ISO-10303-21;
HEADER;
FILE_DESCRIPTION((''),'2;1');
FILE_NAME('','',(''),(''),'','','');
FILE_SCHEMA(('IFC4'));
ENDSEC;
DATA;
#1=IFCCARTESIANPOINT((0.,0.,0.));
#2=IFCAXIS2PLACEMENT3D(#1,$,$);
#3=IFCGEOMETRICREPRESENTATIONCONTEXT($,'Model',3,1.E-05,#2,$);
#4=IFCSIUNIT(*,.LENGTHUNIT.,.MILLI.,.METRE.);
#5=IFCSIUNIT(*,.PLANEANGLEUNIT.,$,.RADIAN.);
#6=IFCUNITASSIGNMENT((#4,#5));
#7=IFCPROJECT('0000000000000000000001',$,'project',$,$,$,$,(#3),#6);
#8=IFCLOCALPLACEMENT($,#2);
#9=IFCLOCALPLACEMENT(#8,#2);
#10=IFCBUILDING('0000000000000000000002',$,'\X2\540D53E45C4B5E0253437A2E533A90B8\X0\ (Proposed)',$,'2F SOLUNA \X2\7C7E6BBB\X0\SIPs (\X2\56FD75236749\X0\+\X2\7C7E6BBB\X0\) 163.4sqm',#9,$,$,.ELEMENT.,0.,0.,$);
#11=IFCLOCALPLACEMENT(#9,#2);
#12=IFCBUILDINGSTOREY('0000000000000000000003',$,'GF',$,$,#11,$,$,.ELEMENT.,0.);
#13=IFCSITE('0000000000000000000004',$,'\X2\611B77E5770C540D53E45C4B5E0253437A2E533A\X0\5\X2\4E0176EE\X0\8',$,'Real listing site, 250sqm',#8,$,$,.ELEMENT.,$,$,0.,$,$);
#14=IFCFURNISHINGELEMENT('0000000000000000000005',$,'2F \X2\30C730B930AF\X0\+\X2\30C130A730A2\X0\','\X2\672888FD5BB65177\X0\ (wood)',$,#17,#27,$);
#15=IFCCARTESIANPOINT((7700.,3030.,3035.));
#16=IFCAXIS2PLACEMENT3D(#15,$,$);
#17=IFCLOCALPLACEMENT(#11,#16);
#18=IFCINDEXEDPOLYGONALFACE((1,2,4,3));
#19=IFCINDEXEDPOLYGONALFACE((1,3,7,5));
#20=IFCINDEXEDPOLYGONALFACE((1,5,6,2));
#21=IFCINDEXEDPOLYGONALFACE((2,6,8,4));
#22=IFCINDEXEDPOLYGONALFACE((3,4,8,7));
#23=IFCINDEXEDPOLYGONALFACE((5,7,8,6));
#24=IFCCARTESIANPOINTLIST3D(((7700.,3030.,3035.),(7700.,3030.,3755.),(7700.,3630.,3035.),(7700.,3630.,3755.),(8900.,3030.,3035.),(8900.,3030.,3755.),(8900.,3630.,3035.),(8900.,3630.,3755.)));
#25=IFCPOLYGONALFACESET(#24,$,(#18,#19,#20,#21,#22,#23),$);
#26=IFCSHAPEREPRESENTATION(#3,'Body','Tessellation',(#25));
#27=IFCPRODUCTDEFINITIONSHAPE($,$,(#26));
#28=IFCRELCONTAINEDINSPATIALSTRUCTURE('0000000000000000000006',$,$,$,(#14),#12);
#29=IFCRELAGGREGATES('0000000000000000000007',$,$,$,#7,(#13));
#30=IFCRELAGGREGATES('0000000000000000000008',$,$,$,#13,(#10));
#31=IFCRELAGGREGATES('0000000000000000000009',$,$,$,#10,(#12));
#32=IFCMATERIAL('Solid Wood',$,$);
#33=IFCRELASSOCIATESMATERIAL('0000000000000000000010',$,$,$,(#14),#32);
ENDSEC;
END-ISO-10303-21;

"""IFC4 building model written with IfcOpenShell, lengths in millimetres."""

from ifc_helpers import new_model, si_unit, frame, frame_2d, origin, place, context, project, spatial, rectangle, extrude, material, element, save


model = new_model("IFC4")

# Units and contexts
model_context = context("Model", 3, precision=1e-05, world=origin())
ifc_project = project(units=[si_unit("LENGTHUNIT", "METRE", prefix="MILLI"), si_unit("PLANEANGLEUNIT", "RADIAN")], contexts=[model_context])

# Site, building, storey
site_placement = place(None, origin())
site = spatial("IfcSite", under=ifc_project, at=site_placement, Name="愛知県名古屋市千種区5丁目8", ObjectType="Real listing site, 250sqm", CompositionType="ELEMENT", RefElevation=0.0)
building_placement = place(site_placement, origin())
building = spatial("IfcBuilding", under=site, at=building_placement, Name="名古屋市千種区邸 (Proposed)", ObjectType="2F SOLUNA 籾殻SIPs (国産杉+籾殻) 163.4sqm", CompositionType="ELEMENT", ElevationOfRefHeight=0.0, ElevationOfTerrain=0.0)
storey_placement = place(building_placement, origin())
storey = spatial("IfcBuildingStorey", under=building, at=storey_placement, Name="GF", CompositionType="ELEMENT", Elevation=0.0)

# Shared definitions
ifc_material_1 = material(Name="Solid Wood")

# Furnishing element
furnishing_1_placement = place(storey_placement, frame((7700.0, 3030.0, 3035.0)))
element("IfcFurnishingElement", 1, at=furnishing_1_placement, inside=storey, material=ifc_material_1, Name="2F デスク+チェア", Description="木製家具 (wood)", context=model_context, shape_type="SweptSolid", body=[
    extrude(rectangle(XDim=1200.0, YDim=600.0, at=frame_2d((600.0, 300.0))), frame((7700.0, 3030.0, 3035.0)), (0.0, 0.0, 1.0), 720.0),
])

save(model, "model.ifc")
